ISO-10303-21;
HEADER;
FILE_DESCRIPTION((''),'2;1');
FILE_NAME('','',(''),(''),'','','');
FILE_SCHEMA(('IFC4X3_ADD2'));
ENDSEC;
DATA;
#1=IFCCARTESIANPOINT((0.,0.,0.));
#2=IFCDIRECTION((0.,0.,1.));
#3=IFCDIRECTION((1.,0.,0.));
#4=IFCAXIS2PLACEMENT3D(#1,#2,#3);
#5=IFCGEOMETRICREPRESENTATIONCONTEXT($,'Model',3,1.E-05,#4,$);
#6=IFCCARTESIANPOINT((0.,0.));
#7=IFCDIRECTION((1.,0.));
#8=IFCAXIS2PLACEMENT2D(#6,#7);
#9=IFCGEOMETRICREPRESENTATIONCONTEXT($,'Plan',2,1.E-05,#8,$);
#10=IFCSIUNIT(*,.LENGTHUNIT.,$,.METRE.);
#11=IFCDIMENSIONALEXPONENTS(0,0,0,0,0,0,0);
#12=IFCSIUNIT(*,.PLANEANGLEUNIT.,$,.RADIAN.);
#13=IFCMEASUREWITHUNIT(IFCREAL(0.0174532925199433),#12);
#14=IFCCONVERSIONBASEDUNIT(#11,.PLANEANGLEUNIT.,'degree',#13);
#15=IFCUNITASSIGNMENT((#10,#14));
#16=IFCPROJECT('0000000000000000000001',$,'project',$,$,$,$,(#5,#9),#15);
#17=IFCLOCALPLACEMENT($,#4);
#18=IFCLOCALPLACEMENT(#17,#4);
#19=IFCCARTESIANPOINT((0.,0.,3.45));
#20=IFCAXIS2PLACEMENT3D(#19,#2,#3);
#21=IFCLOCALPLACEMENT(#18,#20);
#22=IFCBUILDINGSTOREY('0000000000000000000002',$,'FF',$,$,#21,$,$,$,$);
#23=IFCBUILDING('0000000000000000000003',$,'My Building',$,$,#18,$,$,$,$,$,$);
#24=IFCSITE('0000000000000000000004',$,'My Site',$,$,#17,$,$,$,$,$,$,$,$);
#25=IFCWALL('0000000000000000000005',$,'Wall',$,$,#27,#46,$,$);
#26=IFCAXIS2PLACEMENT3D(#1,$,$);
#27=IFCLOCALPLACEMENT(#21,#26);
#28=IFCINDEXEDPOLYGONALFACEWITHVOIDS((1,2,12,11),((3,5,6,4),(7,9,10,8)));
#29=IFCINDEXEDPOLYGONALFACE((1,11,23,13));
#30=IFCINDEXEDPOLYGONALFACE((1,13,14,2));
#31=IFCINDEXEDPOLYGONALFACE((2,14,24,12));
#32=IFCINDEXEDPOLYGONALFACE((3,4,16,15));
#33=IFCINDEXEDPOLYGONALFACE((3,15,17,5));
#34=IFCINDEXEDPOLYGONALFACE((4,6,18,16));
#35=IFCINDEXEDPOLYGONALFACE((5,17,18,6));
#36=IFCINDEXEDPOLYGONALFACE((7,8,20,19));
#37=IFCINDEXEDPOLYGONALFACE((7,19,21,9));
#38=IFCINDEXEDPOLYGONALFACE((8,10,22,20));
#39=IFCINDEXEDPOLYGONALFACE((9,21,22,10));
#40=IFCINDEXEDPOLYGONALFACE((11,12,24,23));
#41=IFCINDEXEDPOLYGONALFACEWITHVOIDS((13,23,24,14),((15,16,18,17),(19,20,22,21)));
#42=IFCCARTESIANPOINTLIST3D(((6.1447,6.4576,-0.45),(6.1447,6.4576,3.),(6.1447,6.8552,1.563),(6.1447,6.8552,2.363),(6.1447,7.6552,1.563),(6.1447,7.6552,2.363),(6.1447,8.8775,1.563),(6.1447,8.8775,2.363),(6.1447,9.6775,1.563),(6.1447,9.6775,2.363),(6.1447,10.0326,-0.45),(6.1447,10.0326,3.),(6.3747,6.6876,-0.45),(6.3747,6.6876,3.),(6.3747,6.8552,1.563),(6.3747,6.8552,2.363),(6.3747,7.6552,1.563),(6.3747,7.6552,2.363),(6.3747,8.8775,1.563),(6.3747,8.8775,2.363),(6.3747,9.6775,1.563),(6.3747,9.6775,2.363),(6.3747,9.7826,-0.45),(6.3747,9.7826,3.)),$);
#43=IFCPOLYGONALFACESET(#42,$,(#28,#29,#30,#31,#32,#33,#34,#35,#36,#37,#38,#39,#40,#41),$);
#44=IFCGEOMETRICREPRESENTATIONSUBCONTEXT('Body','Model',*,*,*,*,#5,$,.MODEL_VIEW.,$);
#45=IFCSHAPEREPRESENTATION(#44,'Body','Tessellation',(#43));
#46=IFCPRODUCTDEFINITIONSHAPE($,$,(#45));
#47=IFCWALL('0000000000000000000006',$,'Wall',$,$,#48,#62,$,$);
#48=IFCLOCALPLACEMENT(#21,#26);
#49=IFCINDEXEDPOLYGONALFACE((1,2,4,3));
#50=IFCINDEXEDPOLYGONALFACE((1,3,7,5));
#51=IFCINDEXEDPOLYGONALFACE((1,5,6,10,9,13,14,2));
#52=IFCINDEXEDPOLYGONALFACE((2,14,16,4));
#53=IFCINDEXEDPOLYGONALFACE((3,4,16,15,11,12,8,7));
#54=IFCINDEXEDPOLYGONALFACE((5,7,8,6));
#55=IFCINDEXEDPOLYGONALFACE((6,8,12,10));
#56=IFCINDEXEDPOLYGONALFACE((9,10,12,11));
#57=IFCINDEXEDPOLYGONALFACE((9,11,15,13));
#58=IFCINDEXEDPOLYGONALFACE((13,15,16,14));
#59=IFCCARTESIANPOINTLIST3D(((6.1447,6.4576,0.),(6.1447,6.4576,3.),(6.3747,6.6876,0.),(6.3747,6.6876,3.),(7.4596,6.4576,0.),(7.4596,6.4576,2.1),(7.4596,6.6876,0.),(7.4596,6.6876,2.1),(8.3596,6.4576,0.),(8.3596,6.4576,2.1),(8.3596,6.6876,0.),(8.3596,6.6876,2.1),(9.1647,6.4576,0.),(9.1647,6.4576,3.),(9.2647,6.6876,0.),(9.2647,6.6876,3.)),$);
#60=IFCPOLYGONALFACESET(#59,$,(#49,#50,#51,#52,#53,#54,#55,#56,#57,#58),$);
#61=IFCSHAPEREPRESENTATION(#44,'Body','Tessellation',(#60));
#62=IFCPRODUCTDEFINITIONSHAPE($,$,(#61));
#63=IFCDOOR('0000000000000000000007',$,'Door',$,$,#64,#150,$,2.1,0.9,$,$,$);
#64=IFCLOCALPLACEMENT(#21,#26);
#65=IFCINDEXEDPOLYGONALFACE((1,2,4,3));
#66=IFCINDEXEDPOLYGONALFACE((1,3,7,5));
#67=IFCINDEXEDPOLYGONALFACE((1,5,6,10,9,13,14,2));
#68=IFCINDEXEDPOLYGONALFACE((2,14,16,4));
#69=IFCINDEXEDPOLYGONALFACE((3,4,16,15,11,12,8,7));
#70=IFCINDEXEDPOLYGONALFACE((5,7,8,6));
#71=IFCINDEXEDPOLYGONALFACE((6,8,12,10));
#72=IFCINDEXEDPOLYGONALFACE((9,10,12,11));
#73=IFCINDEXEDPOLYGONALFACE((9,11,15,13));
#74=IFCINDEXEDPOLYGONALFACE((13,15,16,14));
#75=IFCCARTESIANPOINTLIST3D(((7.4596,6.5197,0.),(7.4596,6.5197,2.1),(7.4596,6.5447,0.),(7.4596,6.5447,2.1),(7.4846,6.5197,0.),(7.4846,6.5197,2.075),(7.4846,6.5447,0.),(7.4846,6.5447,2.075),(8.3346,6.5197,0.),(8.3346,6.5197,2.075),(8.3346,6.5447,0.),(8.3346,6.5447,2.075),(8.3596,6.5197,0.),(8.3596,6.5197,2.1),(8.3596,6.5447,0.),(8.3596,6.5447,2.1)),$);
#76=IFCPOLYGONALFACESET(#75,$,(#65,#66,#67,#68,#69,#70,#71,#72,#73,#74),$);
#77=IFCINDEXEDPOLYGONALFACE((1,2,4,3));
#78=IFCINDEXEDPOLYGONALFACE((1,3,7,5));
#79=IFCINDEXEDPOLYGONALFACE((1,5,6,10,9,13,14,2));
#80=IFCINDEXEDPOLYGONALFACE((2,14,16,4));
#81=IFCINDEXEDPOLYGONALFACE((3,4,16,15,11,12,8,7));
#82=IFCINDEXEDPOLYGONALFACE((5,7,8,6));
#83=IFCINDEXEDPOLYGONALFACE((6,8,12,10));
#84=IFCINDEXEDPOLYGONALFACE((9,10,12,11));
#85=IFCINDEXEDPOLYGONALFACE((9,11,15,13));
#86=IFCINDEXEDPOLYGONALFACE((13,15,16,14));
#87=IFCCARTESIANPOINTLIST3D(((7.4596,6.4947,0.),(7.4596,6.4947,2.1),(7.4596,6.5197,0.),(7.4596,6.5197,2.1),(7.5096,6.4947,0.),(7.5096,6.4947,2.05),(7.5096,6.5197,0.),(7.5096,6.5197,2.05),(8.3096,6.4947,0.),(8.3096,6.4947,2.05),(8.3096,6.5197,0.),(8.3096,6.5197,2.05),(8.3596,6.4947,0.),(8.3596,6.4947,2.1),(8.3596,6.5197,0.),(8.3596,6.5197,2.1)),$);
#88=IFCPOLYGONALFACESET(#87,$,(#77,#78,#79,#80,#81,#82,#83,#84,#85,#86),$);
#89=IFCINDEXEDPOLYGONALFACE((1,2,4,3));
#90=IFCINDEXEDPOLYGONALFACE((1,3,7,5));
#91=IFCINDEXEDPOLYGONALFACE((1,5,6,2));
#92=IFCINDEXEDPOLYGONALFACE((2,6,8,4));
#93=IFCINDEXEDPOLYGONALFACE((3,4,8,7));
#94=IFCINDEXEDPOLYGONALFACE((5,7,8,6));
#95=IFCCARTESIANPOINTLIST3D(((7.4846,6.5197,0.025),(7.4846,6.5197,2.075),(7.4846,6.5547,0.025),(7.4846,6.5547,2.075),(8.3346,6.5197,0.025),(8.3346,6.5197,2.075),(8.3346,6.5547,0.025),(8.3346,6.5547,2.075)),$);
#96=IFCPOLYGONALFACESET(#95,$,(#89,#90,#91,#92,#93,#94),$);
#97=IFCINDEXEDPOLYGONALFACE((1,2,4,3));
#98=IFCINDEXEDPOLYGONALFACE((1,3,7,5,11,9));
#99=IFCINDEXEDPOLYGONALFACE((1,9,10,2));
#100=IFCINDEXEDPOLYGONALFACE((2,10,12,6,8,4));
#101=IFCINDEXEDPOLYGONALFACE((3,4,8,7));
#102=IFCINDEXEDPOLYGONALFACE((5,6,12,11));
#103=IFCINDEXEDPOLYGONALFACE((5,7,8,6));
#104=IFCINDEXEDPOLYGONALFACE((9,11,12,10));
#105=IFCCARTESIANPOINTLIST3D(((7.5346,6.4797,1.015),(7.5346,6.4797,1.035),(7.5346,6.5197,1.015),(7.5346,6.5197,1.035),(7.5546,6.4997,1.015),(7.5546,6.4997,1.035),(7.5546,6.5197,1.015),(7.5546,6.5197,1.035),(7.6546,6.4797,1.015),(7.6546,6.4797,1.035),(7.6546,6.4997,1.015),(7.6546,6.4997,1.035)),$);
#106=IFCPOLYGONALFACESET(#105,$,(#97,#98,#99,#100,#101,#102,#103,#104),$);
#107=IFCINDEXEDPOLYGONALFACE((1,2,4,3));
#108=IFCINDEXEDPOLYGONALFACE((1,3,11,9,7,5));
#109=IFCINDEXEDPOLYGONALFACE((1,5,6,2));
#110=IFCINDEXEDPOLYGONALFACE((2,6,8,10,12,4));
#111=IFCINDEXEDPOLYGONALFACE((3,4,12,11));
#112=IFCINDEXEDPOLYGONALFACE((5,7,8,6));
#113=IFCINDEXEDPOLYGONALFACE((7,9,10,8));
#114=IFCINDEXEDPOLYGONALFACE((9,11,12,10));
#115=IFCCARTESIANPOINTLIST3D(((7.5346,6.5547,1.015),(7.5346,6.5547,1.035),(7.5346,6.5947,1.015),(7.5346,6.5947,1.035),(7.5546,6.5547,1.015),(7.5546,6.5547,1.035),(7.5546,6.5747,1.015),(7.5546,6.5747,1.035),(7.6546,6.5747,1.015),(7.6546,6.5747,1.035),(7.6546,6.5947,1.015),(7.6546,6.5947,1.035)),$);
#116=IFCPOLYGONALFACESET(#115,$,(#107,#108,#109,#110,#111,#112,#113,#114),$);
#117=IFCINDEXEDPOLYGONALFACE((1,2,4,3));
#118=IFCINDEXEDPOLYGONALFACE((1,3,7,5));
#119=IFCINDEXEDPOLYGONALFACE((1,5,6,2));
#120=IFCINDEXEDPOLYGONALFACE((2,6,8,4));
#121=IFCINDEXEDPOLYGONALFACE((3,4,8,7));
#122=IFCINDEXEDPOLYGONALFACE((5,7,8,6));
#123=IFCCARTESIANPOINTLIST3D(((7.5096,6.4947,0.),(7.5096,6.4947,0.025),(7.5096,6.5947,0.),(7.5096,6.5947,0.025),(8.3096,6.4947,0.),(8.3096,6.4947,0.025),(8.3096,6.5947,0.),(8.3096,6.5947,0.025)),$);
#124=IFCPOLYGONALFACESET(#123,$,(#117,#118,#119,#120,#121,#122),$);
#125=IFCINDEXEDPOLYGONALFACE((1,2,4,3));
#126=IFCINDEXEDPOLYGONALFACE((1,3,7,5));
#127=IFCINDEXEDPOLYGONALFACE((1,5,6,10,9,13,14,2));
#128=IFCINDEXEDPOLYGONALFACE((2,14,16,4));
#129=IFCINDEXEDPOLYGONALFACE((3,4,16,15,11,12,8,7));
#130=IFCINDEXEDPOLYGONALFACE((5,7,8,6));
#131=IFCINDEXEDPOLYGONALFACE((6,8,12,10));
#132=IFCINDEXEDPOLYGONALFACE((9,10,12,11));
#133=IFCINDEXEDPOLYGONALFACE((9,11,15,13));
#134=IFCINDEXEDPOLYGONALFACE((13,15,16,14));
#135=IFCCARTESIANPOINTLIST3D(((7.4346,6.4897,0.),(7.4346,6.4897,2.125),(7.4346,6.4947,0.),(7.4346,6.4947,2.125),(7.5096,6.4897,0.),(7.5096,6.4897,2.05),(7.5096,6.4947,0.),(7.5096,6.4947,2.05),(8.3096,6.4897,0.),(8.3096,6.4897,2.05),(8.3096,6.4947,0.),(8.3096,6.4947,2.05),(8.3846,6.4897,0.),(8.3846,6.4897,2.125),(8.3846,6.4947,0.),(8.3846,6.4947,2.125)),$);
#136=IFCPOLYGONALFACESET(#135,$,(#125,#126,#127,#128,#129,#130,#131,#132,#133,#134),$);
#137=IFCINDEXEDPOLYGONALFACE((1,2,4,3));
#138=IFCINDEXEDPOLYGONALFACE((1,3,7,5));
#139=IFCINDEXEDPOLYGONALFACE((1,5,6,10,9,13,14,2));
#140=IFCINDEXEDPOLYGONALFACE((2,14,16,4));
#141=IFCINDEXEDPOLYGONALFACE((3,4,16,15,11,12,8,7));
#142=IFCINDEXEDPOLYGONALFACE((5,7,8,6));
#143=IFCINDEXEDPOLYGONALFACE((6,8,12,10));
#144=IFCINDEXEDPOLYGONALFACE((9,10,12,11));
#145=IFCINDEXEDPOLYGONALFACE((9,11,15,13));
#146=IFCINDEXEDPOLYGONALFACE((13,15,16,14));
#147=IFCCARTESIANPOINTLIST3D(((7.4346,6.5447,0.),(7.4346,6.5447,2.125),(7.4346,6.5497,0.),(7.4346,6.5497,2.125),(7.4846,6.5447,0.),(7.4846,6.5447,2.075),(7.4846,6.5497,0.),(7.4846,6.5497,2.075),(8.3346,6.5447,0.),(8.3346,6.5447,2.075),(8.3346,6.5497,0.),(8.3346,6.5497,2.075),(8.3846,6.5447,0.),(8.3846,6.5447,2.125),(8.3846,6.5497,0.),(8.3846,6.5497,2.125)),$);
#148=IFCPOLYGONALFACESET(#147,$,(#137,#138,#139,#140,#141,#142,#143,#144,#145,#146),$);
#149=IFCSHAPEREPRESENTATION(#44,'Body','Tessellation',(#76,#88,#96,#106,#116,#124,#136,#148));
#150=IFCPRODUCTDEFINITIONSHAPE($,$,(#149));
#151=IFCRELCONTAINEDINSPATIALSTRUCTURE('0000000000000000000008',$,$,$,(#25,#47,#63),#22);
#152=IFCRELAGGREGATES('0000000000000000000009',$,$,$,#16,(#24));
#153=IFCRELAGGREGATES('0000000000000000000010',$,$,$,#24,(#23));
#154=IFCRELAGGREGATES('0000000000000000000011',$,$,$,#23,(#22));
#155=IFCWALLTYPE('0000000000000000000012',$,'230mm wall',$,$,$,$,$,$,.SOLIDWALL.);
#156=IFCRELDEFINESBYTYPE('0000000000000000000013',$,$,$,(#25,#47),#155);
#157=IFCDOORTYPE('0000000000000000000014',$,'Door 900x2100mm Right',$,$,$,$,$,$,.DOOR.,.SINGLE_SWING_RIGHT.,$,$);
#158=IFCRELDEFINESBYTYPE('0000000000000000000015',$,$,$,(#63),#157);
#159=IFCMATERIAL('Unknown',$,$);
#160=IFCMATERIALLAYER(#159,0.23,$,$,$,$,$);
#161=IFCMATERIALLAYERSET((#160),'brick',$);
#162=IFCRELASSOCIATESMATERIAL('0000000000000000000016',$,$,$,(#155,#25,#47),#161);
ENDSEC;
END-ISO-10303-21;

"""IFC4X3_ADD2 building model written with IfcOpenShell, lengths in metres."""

from ifc_helpers import new_model, entity, si_unit, converted_unit, frame, origin_with_axes, origin_2d_with_axis, place, context, subcontext, project, spatial, line, indexed_curve, outline, extrude, shape, source, transform, mapped, material, layer, layer_set, layer_usage, type_object, type_shapes, element, fill, save


model = new_model("IFC4X3_ADD2")

# Units and contexts
model_context = context("Model", 3, precision=1e-05, world=origin_with_axes())
plan_context = context("Plan", 2, precision=1e-05, world=origin_2d_with_axis())
body_context_1 = subcontext(model_context, "Body", "Model", "MODEL_VIEW")
body_context_2 = subcontext(plan_context, "Body", "Plan", "PLAN_VIEW")
ifc_project = project(units=[si_unit("LENGTHUNIT", "METRE"), converted_unit("PLANEANGLEUNIT", "degree", entity("IfcReal", 0.0174532925199433), si_unit("PLANEANGLEUNIT", "RADIAN"), dimensions=[0, 0, 0, 0, 0, 0, 0])], contexts=[model_context, plan_context])

# Site, building, storey
site_placement = place(None, origin_with_axes())
site = spatial("IfcSite", under=ifc_project, at=site_placement, Name="My Site")
building_placement = place(site_placement, origin_with_axes())
building = spatial("IfcBuilding", under=site, at=building_placement, Name="My Building")
storey_placement = place(building_placement, frame((0.0, 0.0, 3.45), z_axis=(0.0, 0.0, 1.0), x_axis=(1.0, 0.0, 0.0)))
storey = spatial("IfcBuildingStorey", under=building, at=storey_placement, Name="FF")

# Shared definitions
ifc_material = material(Name="Unknown")

# Shared definitions
ifc_layer_1 = layer(ifc_material, 0.23)
ifc_layer_set_1 = layer_set([ifc_layer_1], Name="brick")
wall_type_1 = type_object("IfcWallType", Name="230mm wall", PredefinedType="SOLIDWALL", material=ifc_layer_set_1)

# Wall, openings
ifc_layer_usage_1 = layer_usage(ifc_layer_set_1, "AXIS2", "POSITIVE", 0.0)
wall_1_placement = place(storey_placement, frame((6.3747, 6.6876, -0.45), z_axis=(0.0, 0.0, 1.0), x_axis=(0.0, 1.0, 0.0)))
wall_1 = element("IfcWall", 1, at=wall_1_placement, inside=storey, type_object=wall_type_1, material=ifc_layer_usage_1, Name="Wall", context=body_context_1, shape_type="SweptSolid", body=[
    extrude(outline(indexed_curve([(0.0, 0.0), (-0.23, 0.23), (3.345, 0.23), (3.095, 0.0)], segments=[line(1, 2, 3, 4, 1)])), origin_with_axes(), (0.0, 0.0, 1.0), 3.45),
])
shared_shape_1 = source(origin_with_axes(), body_context_1, "Body", "SweptSolid", [
    extrude(outline(indexed_curve([(0.0, 0.0), (0.8, 0.0), (0.8, 0.8), (0.0, 0.8)], segments=[line(1, 2, 3, 4, 1)])), frame((-0.4, -0.6, 0.0), z_axis=(0.0, -1.0, 0.0), x_axis=(1.0, 0.0, 0.0)), (0.0, 0.0, -1.0), 1.2),
])
opening_1_placement = place(wall_1_placement, frame((2.5899, 0.0, 2.013), z_axis=(0.0, 0.0, 1.0), x_axis=(1.0, 0.0, 0.0)))
element("IfcOpeningElement", 2, at=opening_1_placement, cuts=wall_1, PredefinedType="OPENING", context=body_context_1, shape_type="MappedRepresentation", body=[
    mapped(shared_shape_1, transform((0.0, 0.0, 0.0), x_axis=(1.0, 0.0, 0.0), y_axis=(0.0, 1.0, 0.0), z_axis=(0.0, 0.0, 1.0), scale=1.0)),
])
opening_2_placement = place(wall_1_placement, frame((0.5677, 0.0, 2.013), z_axis=(0.0, 0.0, 1.0), x_axis=(1.0, 0.0, 0.0)))
element("IfcOpeningElement", 3, at=opening_2_placement, cuts=wall_1, PredefinedType="OPENING", context=body_context_1, shape_type="MappedRepresentation", body=[
    mapped(shared_shape_1, transform((0.0, 0.0, 0.0), x_axis=(1.0, 0.0, 0.0), y_axis=(0.0, 1.0, 0.0), z_axis=(0.0, 0.0, 1.0), scale=1.0)),
])

# Wall, opening, door
ifc_layer_usage_2 = layer_usage(ifc_layer_set_1, "AXIS2", "POSITIVE", 0.0)
wall_2_placement = place(storey_placement, frame((9.2647, 6.6876, 0.0), z_axis=(0.0, 0.0, 1.0), x_axis=(-1.0, 0.0, 0.0)))
wall_2 = element("IfcWall", 4, at=wall_2_placement, inside=storey, type_object=wall_type_1, material=ifc_layer_usage_2, Name="Wall", context=body_context_1, shape_type="SweptSolid", body=[
    extrude(outline(indexed_curve([(0.0, 0.0), (0.1, 0.23), (3.12, 0.23), (2.89, 0.0)], segments=[line(1, 2, 3, 4, 1)])), origin_with_axes(), (0.0, 0.0, 1.0), 3.0),
])
shared_shape_2 = source(origin_with_axes(), body_context_1, "Body", "SolidModel", [
    extrude(outline(indexed_curve([(0.0, 0.0), (0.9, 0.0), (0.9, 2.1), (0.0, 2.1)], segments=[line(1, 2, 3, 4, 1)])), frame((0.0, -0.6, 0.0), z_axis=(0.0, -1.0, 0.0), x_axis=(1.0, 0.0, 0.0)), (0.0, 0.0, -1.0), 1.2),
])
opening_3_placement = place(wall_2_placement, frame((1.8051, 0.0801, 0.0), z_axis=(0.0, 0.0, 1.0), x_axis=(-1.0, 0.0, 0.0)))
opening_3 = element("IfcOpeningElement", 5, at=opening_3_placement, cuts=wall_2, PredefinedType="OPENING", context=body_context_1, shape_type="MappedRepresentation", body=[
    mapped(shared_shape_2, transform((0.0, 0.0, 0.0), x_axis=(1.0, 0.0, 0.0), y_axis=(0.0, 1.0, 0.0), z_axis=(0.0, 0.0, 1.0), scale=1.0)),
])
door_type_1 = type_object("IfcDoorType", Name="Door 900x2100mm Right", OperationType="SINGLE_SWING_RIGHT", PredefinedType="DOOR")
shared_shape_3 = source(origin_with_axes(), body_context_1, "Body", "SweptSolid", [
    extrude(outline(indexed_curve([(0.0, 0.0), (0.0, 2.1), (0.9, 2.1), (0.9, 0.0), (0.875, 0.0), (0.875, 2.075), (0.025, 2.075), (0.025, 0.0)], segments=[line(1, 2, 3, 4, 5, 6, 7, 8, 1)])), frame((0.0, 0.025, 0.0), z_axis=(0.0, -1.0, 0.0), x_axis=(1.0, 0.0, 0.0)), (0.0, 0.0, -1.0), 0.025),
    extrude(outline(indexed_curve([(0.0, 0.0), (0.0, 2.1), (0.9, 2.1), (0.9, 0.0), (0.85, 0.0), (0.85, 2.05), (0.05, 2.05), (0.05, 0.0)], segments=[line(1, 2, 3, 4, 5, 6, 7, 8, 1)])), frame((0.0, 0.0, 0.0), z_axis=(0.0, -1.0, 0.0), x_axis=(1.0, 0.0, 0.0)), (0.0, 0.0, -1.0), 0.025),
    extrude(outline(indexed_curve([(0.0, 0.0), (0.85, 0.0), (0.85, 0.035), (0.0, 0.035)], segments=[line(1, 2, 3, 4, 1)])), frame((0.025, 0.025, 0.025), z_axis=(0.0, 0.0, 1.0), x_axis=(1.0, 0.0, 0.0)), (0.0, 0.0, 1.0), 2.05),
    extrude(outline(indexed_curve([(0.0, 0.0), (0.0, -0.04), (0.12, -0.04), (0.12, -0.02), (0.02, -0.02), (0.02, 0.0)], segments=[line(1, 2, 3, 4, 5, 6, 1)])), frame((0.075, 0.025, 1.015), z_axis=(0.0, 0.0, 1.0), x_axis=(1.0, 0.0, 0.0)), (0.0, 0.0, 1.0), 0.02),
    extrude(outline(indexed_curve([(0.0, 0.0), (0.0, 0.04), (0.12, 0.04), (0.12, 0.02), (0.02, 0.02), (0.02, 0.0)], segments=[line(1, 2, 3, 4, 5, 6, 1)])), frame((0.075, 0.06, 1.015), z_axis=(0.0, 0.0, 1.0), x_axis=(1.0, 0.0, 0.0)), (0.0, 0.0, 1.0), 0.02),
    extrude(outline(indexed_curve([(0.0, 0.0), (0.8, 0.0), (0.8, 0.1), (0.0, 0.1)], segments=[line(1, 2, 3, 4, 1)])), frame((0.05, 0.0, 0.0), z_axis=(0.0, 0.0, 1.0), x_axis=(1.0, 0.0, 0.0)), (0.0, 0.0, 1.0), 0.025),
    extrude(outline(indexed_curve([(0.0, 0.0), (0.0, 2.125), (0.95, 2.125), (0.95, 0.0), (0.875, 0.0), (0.875, 2.05), (0.075, 2.05), (0.075, 0.0)], segments=[line(1, 2, 3, 4, 5, 6, 7, 8, 1)])), frame((-0.025, -0.005, 0.0), z_axis=(0.0, -1.0, 0.0), x_axis=(1.0, 0.0, 0.0)), (0.0, 0.0, -1.0), 0.005),
    extrude(outline(indexed_curve([(0.0, 0.0), (0.0, 2.125), (0.95, 2.125), (0.95, 0.0), (0.9, 0.0), (0.9, 2.075), (0.05, 2.075), (0.05, 0.0)], segments=[line(1, 2, 3, 4, 5, 6, 7, 8, 1)])), frame((-0.025, 0.05, 0.0), z_axis=(0.0, -1.0, 0.0), x_axis=(1.0, 0.0, 0.0)), (0.0, 0.0, -1.0), 0.005),
])
shared_shape_4 = source(origin_with_axes(), body_context_2, "Body", "Curve2D", [
    entity("IfcIndexedPolyCurve", entity("IfcCartesianPointList2D", [[0.0, 0.0], [0.0, 0.05], [0.025, 0.05], [0.025, 0.025], [0.05, 0.025], [0.05, 0.0]]), [entity("IfcLineIndex", [1, 2, 3, 4, 5, 6, 1])]),
    entity("IfcIndexedPolyCurve", entity("IfcCartesianPointList2D", [[0.9, 0.0], [0.9, 0.05], [0.875, 0.05], [0.875, 0.025], [0.85, 0.025], [0.85, 0.0]]), [entity("IfcLineIndex", [1, 2, 3, 4, 5, 6, 1])]),
    entity("IfcTrimmedCurve", entity("IfcEllipse", entity("IfcAxis2Placement2D", entity("IfcCartesianPoint", [0.84, 0.05]), entity("IfcDirection", [1.0, 0.0])), 0.815, 0.85), [entity("IfcCartesianPoint", [0.84, 0.9])], [entity("IfcCartesianPoint", [0.025, 0.05])], True, "CARTESIAN"),
    entity("IfcIndexedPolyCurve", entity("IfcCartesianPointList2D", [[0.875, 0.05], [0.84, 0.05], [0.84, 0.9], [0.875, 0.9]]), [entity("IfcLineIndex", [1, 2, 3, 4, 1])]),
])
type_shapes(door_type_1, [shared_shape_3, shared_shape_4])
door_1_placement = place(opening_3_placement, frame((0.0, -0.1128, 0.0), z_axis=(0.0, 0.0, 1.0), x_axis=(1.0, 0.0, 0.0)))
door_1 = element("IfcDoor", 6, at=door_1_placement, inside=storey, type_object=door_type_1, Name="Door", OverallHeight=2.1, OverallWidth=0.9, shapes=[
    shape(body_context_1, "Body", "MappedRepresentation", [mapped(shared_shape_3, transform((0.0, 0.0, 0.0), x_axis=(1.0, 0.0, 0.0), y_axis=(0.0, 1.0, 0.0), z_axis=(0.0, 0.0, 1.0), scale=1.0))]),
    shape(body_context_2, "Body", "MappedRepresentation", [mapped(shared_shape_4, transform((0.0, 0.0, 0.0), x_axis=(1.0, 0.0, 0.0), y_axis=(0.0, 1.0, 0.0), z_axis=(0.0, 0.0, 1.0), scale=1.0))]),
])
fill(opening_3, door_1)

save(model, "model.ifc")
